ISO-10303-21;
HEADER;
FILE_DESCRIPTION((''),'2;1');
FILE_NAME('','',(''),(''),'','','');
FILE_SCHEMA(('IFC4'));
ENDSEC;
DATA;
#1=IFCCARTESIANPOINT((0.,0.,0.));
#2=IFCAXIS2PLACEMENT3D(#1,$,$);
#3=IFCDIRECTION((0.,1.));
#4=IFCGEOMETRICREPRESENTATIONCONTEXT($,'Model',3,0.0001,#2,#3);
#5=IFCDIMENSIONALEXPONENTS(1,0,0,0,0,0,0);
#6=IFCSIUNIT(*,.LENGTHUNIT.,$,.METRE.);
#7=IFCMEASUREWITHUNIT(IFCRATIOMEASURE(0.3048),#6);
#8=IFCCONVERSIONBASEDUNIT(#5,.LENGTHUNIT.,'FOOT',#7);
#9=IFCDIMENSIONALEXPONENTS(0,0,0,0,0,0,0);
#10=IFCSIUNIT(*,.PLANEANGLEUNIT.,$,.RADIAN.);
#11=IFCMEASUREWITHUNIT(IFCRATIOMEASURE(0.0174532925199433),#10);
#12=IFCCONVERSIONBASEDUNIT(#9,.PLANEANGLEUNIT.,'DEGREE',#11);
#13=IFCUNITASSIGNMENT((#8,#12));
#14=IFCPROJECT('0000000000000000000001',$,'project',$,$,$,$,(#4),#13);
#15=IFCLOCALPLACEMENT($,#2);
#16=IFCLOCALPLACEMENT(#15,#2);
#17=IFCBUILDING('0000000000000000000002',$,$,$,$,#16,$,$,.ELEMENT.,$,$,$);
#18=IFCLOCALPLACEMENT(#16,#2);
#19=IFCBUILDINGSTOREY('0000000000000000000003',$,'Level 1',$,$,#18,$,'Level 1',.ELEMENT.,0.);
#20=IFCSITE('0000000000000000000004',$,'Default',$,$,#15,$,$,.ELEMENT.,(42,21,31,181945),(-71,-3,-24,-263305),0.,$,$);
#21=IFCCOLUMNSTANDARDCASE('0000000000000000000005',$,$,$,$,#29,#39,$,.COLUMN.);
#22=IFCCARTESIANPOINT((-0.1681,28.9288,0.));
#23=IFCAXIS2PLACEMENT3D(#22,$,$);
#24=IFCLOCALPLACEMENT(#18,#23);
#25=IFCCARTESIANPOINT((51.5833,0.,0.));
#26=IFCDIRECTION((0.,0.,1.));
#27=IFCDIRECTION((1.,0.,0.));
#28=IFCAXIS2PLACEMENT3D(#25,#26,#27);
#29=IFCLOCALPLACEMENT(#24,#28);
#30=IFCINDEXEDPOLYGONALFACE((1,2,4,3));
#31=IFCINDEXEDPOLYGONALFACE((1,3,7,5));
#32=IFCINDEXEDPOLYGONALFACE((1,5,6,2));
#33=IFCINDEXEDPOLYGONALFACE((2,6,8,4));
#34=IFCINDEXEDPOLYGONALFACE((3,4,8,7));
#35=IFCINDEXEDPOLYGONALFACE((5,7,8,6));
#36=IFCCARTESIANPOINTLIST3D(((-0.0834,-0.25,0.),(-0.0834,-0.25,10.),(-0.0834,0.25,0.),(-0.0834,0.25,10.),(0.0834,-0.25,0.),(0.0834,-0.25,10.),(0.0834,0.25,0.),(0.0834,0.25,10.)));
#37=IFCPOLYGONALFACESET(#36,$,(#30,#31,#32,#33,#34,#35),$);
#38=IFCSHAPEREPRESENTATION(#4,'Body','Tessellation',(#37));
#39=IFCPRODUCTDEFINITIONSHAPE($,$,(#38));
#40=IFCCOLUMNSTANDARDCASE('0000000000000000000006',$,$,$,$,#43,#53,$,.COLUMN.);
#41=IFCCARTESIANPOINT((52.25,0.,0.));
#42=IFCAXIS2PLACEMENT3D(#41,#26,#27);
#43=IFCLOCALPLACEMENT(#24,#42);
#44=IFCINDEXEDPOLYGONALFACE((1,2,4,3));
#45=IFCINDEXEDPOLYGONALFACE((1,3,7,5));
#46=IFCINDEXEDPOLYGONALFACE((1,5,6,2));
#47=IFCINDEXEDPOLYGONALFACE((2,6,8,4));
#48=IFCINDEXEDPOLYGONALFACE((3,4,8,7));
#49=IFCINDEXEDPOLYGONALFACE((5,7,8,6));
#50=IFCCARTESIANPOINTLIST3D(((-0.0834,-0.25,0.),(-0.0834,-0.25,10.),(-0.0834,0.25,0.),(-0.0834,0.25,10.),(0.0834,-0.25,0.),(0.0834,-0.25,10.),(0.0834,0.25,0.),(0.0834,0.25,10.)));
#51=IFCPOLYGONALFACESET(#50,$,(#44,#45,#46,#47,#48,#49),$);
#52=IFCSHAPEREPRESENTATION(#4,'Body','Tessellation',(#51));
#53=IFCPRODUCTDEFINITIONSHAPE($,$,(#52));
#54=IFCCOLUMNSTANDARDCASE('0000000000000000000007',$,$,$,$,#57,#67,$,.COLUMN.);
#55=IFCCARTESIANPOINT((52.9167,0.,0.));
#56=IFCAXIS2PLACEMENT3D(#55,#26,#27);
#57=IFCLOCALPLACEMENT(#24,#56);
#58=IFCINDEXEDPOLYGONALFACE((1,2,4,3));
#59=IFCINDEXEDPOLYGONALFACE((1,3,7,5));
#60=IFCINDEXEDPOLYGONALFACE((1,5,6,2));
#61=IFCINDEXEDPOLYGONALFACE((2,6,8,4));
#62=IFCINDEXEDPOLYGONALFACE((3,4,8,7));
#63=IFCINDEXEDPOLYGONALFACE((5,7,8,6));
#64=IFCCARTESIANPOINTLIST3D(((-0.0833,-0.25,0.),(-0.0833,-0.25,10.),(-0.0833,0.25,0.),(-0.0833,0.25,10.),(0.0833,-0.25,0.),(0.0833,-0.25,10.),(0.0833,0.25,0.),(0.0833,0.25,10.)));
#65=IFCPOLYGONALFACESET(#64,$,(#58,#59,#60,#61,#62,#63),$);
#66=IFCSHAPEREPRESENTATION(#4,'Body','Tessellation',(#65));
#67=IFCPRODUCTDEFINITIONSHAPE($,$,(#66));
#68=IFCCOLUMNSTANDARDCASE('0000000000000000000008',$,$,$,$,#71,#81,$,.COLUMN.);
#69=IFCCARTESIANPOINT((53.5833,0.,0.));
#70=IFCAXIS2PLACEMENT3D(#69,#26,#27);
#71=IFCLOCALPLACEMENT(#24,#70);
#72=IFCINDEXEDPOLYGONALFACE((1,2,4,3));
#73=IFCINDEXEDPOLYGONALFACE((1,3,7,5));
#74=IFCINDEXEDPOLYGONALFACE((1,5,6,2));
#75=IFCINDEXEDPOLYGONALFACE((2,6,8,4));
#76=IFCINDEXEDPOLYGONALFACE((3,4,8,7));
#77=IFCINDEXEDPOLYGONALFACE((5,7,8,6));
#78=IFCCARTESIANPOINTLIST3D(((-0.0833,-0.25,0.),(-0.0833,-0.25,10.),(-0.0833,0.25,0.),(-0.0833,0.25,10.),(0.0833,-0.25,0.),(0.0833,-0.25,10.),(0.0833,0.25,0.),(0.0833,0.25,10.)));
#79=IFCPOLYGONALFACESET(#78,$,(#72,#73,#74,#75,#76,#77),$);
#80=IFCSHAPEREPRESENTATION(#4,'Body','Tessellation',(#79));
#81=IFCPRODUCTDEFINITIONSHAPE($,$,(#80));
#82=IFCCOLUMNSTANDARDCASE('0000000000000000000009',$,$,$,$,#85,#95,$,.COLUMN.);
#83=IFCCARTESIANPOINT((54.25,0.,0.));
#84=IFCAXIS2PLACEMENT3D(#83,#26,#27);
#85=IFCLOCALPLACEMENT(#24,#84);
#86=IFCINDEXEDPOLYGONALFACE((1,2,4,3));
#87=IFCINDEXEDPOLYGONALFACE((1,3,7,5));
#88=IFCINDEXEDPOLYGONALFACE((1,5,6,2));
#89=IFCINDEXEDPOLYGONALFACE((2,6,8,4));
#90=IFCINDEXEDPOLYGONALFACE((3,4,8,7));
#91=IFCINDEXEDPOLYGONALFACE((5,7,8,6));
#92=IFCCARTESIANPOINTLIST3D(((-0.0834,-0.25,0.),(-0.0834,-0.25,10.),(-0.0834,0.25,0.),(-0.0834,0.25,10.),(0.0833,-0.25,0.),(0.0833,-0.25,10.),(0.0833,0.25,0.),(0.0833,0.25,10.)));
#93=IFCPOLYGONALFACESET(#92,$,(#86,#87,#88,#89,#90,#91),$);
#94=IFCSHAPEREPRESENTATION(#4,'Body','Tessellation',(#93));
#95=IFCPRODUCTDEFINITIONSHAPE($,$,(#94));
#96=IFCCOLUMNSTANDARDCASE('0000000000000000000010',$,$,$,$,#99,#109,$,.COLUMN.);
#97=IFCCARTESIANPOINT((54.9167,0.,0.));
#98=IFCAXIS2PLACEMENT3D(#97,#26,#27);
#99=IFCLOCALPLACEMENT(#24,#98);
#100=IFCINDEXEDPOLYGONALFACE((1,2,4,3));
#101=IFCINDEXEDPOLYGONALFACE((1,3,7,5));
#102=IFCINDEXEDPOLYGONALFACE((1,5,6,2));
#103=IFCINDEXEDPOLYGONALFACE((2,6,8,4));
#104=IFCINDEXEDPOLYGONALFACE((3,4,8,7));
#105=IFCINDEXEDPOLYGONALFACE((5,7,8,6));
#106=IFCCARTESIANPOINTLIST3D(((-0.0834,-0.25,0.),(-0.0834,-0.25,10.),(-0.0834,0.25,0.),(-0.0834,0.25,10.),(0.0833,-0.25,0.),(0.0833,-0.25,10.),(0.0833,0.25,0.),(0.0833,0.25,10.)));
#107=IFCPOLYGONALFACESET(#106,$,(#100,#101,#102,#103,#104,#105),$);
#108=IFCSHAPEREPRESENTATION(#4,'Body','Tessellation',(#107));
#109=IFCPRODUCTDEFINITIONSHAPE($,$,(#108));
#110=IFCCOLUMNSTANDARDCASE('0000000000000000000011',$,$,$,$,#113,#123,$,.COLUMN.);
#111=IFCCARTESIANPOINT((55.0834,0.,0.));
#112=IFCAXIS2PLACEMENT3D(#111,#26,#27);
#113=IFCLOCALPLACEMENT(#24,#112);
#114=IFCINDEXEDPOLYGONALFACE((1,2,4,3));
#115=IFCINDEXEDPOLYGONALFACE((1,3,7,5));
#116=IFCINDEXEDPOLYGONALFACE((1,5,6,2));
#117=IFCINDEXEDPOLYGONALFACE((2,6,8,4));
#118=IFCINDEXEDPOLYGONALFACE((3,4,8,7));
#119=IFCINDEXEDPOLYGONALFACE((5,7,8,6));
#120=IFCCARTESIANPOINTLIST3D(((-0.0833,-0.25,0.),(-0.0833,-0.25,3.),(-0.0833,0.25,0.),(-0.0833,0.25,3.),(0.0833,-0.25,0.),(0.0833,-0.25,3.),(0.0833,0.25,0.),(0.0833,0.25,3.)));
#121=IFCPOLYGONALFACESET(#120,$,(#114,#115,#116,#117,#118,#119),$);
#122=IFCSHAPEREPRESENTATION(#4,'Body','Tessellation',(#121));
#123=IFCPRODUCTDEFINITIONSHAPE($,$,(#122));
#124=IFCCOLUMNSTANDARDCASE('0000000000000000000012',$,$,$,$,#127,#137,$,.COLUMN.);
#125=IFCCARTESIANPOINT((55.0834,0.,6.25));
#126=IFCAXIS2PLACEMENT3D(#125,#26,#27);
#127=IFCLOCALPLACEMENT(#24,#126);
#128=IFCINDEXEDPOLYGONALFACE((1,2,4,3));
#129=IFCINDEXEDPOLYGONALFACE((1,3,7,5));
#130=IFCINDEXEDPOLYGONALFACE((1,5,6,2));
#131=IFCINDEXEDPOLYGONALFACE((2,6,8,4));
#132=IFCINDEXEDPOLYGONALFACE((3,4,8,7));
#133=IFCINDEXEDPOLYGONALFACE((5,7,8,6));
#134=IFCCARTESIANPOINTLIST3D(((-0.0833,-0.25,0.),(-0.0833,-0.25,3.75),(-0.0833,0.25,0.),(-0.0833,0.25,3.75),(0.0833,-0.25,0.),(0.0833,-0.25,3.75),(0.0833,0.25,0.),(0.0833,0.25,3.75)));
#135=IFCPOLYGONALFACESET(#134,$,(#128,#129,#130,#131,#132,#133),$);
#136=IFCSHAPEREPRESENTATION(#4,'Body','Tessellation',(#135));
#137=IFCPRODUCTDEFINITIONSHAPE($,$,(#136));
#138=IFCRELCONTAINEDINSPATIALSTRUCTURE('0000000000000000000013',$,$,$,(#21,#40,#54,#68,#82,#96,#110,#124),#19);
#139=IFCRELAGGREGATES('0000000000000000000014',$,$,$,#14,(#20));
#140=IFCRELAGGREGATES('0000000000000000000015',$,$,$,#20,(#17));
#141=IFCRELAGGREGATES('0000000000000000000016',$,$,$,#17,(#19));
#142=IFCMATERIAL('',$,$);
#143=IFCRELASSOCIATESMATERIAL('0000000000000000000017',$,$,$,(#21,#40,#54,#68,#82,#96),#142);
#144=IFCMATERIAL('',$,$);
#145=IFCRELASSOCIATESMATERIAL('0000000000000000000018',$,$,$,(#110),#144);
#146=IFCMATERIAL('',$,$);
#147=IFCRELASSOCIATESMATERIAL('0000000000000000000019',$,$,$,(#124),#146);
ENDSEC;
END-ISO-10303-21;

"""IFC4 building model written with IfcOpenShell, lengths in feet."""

from ifc_helpers import new_model, entity, si_unit, converted_unit, direction, frame, origin, place, context, project, spatial, rectangle, extrude, material, element, save


model = new_model("IFC4")

# Units and contexts
model_context = context("Model", 3, precision=0.0001, world=origin(), true_north=direction((0.0, 1.0)))
ifc_project = project(units=[converted_unit("LENGTHUNIT", "FOOT", entity("IfcRatioMeasure", 0.3048), si_unit("LENGTHUNIT", "METRE"), dimensions=[1, 0, 0, 0, 0, 0, 0]), converted_unit("PLANEANGLEUNIT", "DEGREE", entity("IfcRatioMeasure", 0.0174532925199433), si_unit("PLANEANGLEUNIT", "RADIAN"), dimensions=[0, 0, 0, 0, 0, 0, 0])], contexts=[model_context])

# Site, building, storey
site_placement = place(None, origin())
site = spatial("IfcSite", under=ifc_project, at=site_placement, Name="Default", CompositionType="ELEMENT", RefLatitude=(42, 21, 31, 181945), RefLongitude=(-71, -3, -24, -263305), RefElevation=0.0)
building_placement = place(site_placement, origin())
building = spatial("IfcBuilding", under=site, at=building_placement, CompositionType="ELEMENT")
storey_placement = place(building_placement, origin())
storey = spatial("IfcBuildingStorey", under=building, at=storey_placement, Name="Level 1", LongName="Level 1", CompositionType="ELEMENT", Elevation=0.0)

# Columns
ifc_material_1 = material(Name="")
placement = place(storey_placement, frame((-0.1681, 28.9288, 0.0)))
for number, where, z_axis, x_axis in (
    (1, (51.5833, 0.0, 0.0), (0.0, 0.0, 1.0), (1.0, 0.0, 0.0)),
    (2, (52.25, 0.0, 0.0), (0.0, 0.0, 1.0), (1.0, 0.0, 0.0)),
    (3, (52.9167, 0.0, 0.0), (0.0, 0.0, 1.0), (1.0, 0.0, 0.0)),
    (4, (53.5833, 0.0, 0.0), (0.0, 0.0, 1.0), (1.0, 0.0, 0.0)),
    (5, (54.25, 0.0, 0.0), (0.0, 0.0, 1.0), (1.0, 0.0, 0.0)),
    (6, (54.9167, 0.0, 0.0), (0.0, 0.0, 1.0), (1.0, 0.0, 0.0)),
):
    element("IfcColumnStandardCase", number, at=place(placement, frame(where, z_axis=z_axis, x_axis=x_axis)), inside=storey, material=ifc_material_1, PredefinedType="COLUMN", context=model_context, shape_type="SweptSolid", body=[
        extrude(rectangle(XDim=0.1667, YDim=0.5), origin(), (0.0, 0.0, 1.0), 10.0),
    ])
ifc_material_2 = material(Name="")
for number, where, z_axis, x_axis in (
    (7, (55.0834, 0.0, 0.0), (0.0, 0.0, 1.0), (1.0, 0.0, 0.0)),
):
    element("IfcColumnStandardCase", number, at=place(placement, frame(where, z_axis=z_axis, x_axis=x_axis)), inside=storey, material=ifc_material_2, PredefinedType="COLUMN", context=model_context, shape_type="SweptSolid", body=[
        extrude(rectangle(XDim=0.1667, YDim=0.5), origin(), (0.0, 0.0, 1.0), 3.0),
    ])
ifc_material_3 = material(Name="")
for number, where, z_axis, x_axis in (
    (8, (55.0834, 0.0, 6.25), (0.0, 0.0, 1.0), (1.0, 0.0, 0.0)),
):
    element("IfcColumnStandardCase", number, at=place(placement, frame(where, z_axis=z_axis, x_axis=x_axis)), inside=storey, material=ifc_material_3, PredefinedType="COLUMN", context=model_context, shape_type="SweptSolid", body=[
        extrude(rectangle(XDim=0.1667, YDim=0.5), origin(), (0.0, 0.0, 1.0), 3.75),
    ])

save(model, "model.ifc")
